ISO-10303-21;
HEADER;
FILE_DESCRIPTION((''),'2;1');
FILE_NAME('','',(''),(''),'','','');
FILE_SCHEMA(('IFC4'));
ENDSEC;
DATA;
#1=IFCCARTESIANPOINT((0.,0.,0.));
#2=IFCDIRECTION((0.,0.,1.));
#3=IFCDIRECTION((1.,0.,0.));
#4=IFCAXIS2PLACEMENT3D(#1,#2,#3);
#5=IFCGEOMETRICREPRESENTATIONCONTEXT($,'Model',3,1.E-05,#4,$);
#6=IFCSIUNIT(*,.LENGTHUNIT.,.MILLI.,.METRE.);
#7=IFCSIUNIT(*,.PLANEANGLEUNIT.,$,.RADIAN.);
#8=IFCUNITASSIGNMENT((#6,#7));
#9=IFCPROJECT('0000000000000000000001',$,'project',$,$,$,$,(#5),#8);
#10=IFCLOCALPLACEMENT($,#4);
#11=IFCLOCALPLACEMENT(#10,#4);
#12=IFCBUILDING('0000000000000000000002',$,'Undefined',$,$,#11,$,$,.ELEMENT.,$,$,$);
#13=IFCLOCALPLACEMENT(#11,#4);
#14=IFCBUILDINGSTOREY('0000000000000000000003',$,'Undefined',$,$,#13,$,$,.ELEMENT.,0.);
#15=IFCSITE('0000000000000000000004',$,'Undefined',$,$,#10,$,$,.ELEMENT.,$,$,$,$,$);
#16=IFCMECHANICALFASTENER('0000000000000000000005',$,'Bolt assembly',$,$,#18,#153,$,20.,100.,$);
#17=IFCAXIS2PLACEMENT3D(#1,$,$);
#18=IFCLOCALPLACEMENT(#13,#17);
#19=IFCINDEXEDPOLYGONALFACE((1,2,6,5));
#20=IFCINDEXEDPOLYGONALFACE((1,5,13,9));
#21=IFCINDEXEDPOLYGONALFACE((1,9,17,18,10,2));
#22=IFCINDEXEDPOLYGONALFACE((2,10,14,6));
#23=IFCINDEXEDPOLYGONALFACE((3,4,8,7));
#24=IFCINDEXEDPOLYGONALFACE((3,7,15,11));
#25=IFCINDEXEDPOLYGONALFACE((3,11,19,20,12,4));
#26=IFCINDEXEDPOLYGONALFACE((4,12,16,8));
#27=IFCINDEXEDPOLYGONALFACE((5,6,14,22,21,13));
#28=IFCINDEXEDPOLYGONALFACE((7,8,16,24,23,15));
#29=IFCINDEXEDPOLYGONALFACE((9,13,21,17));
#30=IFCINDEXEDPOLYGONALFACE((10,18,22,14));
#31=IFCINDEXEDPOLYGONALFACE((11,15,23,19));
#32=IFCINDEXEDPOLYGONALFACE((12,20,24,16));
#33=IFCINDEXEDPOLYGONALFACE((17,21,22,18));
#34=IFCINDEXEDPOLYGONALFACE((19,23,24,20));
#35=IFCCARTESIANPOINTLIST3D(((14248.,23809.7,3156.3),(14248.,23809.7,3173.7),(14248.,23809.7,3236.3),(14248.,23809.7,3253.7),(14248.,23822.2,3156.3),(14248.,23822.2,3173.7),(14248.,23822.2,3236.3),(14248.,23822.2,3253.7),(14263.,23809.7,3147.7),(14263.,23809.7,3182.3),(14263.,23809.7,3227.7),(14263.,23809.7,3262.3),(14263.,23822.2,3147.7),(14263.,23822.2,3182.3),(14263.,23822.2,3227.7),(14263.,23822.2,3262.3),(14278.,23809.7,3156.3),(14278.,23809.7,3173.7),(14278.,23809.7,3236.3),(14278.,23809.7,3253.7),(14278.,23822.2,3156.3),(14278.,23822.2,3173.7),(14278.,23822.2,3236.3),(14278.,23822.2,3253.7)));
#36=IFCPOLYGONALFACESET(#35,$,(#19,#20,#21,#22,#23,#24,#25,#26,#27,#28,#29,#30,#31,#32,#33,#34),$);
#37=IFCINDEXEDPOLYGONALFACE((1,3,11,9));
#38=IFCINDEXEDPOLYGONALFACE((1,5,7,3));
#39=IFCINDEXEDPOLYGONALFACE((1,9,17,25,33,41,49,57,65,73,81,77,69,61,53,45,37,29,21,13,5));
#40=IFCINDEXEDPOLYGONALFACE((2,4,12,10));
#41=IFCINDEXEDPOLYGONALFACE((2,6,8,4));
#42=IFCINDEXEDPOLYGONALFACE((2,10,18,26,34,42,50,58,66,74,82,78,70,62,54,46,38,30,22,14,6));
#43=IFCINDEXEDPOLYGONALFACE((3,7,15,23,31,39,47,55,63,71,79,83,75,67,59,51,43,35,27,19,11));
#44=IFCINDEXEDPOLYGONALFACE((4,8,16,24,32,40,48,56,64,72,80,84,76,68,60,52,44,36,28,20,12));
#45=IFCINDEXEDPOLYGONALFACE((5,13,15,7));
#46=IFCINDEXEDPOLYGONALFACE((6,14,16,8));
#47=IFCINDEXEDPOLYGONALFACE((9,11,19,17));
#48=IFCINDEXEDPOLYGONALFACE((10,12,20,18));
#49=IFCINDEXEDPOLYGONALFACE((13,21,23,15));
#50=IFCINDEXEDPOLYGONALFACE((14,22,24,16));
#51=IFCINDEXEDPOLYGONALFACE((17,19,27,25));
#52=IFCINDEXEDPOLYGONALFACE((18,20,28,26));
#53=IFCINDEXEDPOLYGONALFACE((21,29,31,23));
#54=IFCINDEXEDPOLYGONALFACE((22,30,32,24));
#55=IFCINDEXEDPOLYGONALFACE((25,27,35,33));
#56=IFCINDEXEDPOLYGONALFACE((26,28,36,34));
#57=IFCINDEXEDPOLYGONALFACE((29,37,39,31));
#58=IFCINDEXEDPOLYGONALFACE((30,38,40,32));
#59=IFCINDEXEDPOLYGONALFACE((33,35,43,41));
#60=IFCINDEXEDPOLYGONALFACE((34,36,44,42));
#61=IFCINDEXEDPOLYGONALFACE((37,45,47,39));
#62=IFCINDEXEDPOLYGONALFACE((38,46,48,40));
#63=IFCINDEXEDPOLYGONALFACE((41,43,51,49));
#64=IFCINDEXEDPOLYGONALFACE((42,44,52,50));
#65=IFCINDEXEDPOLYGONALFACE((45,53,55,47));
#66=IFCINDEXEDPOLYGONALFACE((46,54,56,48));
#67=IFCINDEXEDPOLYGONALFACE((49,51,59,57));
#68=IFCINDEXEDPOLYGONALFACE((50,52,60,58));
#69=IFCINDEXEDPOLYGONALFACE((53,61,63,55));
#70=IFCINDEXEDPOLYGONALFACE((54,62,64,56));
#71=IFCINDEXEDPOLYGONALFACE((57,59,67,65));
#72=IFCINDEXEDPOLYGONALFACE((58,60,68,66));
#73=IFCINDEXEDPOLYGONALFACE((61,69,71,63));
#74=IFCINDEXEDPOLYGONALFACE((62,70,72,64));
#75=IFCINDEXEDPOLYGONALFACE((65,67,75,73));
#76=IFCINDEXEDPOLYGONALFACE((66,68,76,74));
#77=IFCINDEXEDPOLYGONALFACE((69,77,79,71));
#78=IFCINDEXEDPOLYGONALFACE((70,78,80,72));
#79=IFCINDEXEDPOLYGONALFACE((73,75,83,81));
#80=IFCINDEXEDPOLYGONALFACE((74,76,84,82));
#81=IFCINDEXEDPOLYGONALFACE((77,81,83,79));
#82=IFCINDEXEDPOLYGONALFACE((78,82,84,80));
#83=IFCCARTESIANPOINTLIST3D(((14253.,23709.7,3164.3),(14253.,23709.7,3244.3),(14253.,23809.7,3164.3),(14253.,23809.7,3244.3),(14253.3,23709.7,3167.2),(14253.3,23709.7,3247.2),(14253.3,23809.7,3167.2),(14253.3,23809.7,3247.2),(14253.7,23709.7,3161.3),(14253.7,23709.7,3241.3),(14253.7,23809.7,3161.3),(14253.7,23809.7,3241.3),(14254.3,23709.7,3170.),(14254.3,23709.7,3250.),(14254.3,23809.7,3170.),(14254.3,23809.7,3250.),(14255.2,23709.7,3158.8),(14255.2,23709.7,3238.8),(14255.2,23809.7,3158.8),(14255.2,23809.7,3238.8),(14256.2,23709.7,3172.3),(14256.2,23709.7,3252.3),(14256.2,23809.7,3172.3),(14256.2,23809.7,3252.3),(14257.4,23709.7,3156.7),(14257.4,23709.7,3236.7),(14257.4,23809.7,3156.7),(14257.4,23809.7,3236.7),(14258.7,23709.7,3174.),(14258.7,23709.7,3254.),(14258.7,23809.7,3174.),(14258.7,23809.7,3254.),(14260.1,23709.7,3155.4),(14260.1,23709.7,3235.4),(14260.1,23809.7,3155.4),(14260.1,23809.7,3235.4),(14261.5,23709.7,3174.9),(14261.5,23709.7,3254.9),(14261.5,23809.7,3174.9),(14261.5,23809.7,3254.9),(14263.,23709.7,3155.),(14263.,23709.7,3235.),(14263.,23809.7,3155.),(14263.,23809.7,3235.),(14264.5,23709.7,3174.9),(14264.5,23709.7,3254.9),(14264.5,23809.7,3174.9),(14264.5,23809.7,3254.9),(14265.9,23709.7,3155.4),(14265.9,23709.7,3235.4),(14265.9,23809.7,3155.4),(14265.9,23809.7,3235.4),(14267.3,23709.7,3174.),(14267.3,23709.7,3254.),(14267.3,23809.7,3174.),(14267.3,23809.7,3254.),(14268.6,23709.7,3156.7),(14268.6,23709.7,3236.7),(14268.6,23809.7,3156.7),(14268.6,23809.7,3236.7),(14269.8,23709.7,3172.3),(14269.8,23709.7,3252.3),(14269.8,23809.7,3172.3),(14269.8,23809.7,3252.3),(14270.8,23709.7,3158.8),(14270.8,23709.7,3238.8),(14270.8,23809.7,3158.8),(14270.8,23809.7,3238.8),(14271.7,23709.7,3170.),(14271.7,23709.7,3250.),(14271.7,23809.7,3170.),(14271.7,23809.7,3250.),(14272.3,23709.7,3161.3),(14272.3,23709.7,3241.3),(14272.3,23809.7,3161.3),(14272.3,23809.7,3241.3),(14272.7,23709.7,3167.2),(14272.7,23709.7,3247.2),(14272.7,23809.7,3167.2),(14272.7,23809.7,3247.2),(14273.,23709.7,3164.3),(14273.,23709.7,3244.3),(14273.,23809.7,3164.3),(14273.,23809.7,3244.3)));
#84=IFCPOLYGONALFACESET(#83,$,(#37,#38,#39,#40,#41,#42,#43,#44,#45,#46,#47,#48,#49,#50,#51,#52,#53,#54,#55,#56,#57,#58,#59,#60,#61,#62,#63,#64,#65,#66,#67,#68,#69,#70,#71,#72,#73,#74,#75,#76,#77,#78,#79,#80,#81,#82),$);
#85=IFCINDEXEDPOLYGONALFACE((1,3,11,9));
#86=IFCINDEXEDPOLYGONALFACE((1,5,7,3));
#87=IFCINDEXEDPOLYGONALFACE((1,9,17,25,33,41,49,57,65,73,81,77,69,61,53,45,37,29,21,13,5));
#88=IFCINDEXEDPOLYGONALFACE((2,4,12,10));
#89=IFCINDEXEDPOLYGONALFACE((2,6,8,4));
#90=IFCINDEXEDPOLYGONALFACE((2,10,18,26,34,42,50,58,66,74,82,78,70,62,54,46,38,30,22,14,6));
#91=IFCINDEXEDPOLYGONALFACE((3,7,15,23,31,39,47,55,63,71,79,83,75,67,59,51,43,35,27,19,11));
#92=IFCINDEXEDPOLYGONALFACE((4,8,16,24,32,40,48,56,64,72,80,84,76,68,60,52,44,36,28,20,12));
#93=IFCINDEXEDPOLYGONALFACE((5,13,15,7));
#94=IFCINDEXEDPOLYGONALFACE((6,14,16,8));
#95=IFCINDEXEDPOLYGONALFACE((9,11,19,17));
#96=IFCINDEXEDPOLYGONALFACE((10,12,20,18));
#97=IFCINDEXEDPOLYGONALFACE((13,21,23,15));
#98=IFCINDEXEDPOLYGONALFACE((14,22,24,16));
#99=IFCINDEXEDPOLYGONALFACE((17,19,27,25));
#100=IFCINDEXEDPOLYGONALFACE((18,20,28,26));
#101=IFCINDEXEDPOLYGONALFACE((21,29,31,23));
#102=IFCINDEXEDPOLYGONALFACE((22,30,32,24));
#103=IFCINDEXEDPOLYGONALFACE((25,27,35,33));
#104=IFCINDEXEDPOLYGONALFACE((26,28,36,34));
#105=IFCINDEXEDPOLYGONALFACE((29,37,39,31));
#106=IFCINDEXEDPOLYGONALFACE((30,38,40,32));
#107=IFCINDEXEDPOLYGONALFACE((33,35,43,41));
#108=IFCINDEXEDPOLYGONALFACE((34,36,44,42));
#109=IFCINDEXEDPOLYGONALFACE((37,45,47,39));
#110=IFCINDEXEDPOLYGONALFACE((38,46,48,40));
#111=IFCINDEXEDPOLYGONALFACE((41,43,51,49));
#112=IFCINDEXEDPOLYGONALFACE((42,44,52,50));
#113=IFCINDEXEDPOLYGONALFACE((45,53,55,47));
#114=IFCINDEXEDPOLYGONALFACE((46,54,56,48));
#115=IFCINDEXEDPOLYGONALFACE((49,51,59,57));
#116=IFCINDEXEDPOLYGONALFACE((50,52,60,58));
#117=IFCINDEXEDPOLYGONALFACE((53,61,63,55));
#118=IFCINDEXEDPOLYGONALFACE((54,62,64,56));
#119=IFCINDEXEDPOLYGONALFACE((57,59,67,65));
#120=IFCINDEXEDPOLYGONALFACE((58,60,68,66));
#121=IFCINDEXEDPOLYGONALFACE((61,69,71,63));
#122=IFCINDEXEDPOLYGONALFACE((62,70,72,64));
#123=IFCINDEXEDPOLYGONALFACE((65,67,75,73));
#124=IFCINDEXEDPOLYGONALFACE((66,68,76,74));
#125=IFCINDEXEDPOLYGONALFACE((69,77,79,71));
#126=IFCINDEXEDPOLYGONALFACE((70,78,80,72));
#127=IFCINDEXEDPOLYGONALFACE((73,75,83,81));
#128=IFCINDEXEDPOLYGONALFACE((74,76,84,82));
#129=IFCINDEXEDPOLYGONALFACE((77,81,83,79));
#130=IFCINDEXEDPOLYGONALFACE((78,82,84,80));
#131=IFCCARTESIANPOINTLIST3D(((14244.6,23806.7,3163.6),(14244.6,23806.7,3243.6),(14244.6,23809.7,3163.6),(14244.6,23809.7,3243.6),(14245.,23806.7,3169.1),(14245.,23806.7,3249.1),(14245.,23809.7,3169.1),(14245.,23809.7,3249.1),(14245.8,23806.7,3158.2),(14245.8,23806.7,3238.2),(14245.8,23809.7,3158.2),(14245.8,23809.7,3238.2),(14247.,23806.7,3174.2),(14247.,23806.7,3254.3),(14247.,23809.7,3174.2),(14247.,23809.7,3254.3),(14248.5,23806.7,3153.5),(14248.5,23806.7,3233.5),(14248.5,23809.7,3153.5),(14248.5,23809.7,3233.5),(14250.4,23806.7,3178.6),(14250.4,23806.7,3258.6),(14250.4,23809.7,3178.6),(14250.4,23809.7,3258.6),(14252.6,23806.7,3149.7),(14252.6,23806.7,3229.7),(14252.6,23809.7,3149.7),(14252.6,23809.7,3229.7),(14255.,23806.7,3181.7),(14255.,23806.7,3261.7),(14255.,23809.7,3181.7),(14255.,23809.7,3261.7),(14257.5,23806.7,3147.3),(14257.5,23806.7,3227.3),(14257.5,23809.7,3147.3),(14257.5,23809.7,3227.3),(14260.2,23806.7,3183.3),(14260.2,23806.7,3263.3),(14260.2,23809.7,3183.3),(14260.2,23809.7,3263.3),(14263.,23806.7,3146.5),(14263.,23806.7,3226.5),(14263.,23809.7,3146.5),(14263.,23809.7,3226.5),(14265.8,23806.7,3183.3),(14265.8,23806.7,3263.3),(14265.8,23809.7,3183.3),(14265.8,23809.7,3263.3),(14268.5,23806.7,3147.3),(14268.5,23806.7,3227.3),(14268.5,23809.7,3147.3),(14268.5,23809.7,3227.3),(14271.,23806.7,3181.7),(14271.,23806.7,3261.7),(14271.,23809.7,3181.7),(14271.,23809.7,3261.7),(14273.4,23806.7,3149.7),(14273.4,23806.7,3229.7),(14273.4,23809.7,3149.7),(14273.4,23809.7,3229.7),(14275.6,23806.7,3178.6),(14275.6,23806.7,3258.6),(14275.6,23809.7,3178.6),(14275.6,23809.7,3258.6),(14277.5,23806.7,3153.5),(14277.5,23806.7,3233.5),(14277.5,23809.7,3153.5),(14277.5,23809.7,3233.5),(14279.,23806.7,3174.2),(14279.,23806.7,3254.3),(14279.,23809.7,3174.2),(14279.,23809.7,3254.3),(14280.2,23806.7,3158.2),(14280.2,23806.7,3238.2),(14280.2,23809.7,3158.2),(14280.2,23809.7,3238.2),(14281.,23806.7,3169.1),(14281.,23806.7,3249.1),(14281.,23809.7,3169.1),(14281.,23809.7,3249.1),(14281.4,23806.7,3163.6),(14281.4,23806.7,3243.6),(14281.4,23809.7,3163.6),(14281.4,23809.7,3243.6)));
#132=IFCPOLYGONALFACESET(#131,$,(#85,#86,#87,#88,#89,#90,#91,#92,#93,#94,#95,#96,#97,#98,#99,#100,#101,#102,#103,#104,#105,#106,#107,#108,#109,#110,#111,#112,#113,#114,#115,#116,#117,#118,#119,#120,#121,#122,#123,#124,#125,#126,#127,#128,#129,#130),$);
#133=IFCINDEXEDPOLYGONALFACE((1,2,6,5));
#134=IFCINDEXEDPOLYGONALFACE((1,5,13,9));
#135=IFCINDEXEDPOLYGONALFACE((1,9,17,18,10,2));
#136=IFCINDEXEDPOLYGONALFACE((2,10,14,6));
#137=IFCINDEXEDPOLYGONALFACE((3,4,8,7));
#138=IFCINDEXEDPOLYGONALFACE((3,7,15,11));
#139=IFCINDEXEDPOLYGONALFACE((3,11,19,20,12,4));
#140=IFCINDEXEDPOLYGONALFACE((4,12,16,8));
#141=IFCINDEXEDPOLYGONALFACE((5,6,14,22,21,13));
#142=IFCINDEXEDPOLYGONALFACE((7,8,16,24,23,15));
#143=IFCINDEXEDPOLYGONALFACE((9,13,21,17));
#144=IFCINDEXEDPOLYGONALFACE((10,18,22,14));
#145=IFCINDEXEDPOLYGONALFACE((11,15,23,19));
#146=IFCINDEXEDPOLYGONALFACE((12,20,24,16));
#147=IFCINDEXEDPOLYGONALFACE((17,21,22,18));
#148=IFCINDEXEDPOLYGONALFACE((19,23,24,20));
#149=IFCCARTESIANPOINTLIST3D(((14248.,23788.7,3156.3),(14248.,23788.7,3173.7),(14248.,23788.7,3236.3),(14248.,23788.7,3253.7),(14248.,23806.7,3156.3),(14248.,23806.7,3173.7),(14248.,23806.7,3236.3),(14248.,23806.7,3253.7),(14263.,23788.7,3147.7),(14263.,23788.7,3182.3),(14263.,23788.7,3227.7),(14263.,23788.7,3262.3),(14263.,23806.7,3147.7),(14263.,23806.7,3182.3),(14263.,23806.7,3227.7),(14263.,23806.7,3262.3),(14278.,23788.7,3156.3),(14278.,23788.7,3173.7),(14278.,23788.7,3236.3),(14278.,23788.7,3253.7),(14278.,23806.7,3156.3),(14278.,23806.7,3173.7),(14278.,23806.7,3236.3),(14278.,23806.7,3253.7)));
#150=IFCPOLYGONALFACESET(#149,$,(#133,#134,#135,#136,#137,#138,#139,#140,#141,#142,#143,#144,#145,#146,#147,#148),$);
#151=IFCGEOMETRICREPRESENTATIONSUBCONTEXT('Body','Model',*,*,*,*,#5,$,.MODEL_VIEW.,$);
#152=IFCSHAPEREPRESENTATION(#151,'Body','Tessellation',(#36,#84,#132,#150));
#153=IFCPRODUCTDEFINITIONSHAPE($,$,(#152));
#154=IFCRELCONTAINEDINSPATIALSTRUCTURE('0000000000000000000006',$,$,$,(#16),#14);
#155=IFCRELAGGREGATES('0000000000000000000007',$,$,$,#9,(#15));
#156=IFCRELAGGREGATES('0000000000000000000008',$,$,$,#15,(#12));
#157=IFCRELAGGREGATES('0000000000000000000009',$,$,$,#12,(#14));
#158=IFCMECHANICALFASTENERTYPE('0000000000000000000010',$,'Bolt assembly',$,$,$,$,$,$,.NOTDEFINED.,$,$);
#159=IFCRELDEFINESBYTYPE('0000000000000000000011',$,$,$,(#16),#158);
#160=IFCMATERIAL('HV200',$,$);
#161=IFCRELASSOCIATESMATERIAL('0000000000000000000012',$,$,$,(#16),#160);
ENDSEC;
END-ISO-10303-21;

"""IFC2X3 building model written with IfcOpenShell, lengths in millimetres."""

from ifc_helpers import new_model, si_unit, frame, origin_with_axes, origin_2d_with_axis, place, context, subcontext, project, spatial, polyline, circle, outline, extrude, source, transform, mapped, material, type_object, element, save


model = new_model("IFC2X3")

# Units and contexts
model_context = context("Model", 3, precision=1e-05, world=origin_with_axes())
body_context = subcontext(model_context, "Body", "Model", "MODEL_VIEW")
ifc_project = project(units=[si_unit("LENGTHUNIT", "METRE", prefix="MILLI"), si_unit("PLANEANGLEUNIT", "RADIAN")], contexts=[model_context])

# Site, building, storey
site_placement = place(None, origin_with_axes())
site = spatial("IfcSite", under=ifc_project, at=site_placement, Name="Undefined", CompositionType="ELEMENT")
building_placement = place(site_placement, origin_with_axes())
building = spatial("IfcBuilding", under=site, at=building_placement, Name="Undefined", CompositionType="ELEMENT")
storey_placement = place(building_placement, origin_with_axes())
storey = spatial("IfcBuildingStorey", under=building, at=storey_placement, Name="Undefined", CompositionType="ELEMENT", Elevation=0.0)

# Mechanical fastener
ifc_material_1 = material(Name="HV200")
mechanical_fastener_type = type_object("IfcMechanicalFastenerType", Name="Bolt assembly")
shared_shape_1 = source(origin_with_axes(), body_context, "Body", "SweptSolid", [
    extrude(outline(polyline([(17.3, 0.0), (8.7, 15.0), (-8.7, 15.0), (-17.3, 0.0), (-8.7, -15.0), (8.7, -15.0), (17.3, 0.0)])), frame((0.0, -12.5, 0.0), z_axis=(0.0, 1.0, 0.0), x_axis=(1.0, 0.0, 0.0)), (0.0, 0.0, 1.0), 12.5),
    extrude(circle(Radius=10.0, at=origin_2d_with_axis()), frame((0.0, 0.0, 0.0), z_axis=(0.0, 1.0, 0.0), x_axis=(1.0, 0.0, 0.0)), (0.0, 0.0, 1.0), 100.0),
    extrude(circle(Radius=18.5, at=origin_2d_with_axis()), frame((0.0, 0.0, 0.0), z_axis=(0.0, 1.0, 0.0), x_axis=(1.0, 0.0, 0.0)), (0.0, 0.0, 1.0), 3.0),
    extrude(outline(polyline([(17.3, 0.0), (8.7, 15.0), (-8.7, 15.0), (-17.3, 0.0), (-8.7, -15.0), (8.7, -15.0), (17.3, 0.0)])), frame((0.0, 3.0, 0.0), z_axis=(0.0, 1.0, 0.0), x_axis=(1.0, 0.0, 0.0)), (0.0, 0.0, 1.0), 18.0),
])
for number, where, z_axis, x_axis, name in (
    (1, (14263.0, 23809.7, 3245.0), (-1.0, 0.0, 0.0), (0.0, 0.0, -1.0), "Bolt assembly"),
):
    element("IfcMechanicalFastener", number, at=place(storey_placement, frame(where, z_axis=z_axis, x_axis=x_axis)), inside=storey, type_object=mechanical_fastener_type, material=ifc_material_1, Name=name, NominalDiameter=20.0, NominalLength=100.0, context=body_context, shape_type="MappedRepresentation", body=[
        mapped(shared_shape_1, transform((0.0, 0.0, 0.0))),
        mapped(shared_shape_1, transform((80.0, 0.0, 0.0))),
    ])

save(model, "model.ifc")
